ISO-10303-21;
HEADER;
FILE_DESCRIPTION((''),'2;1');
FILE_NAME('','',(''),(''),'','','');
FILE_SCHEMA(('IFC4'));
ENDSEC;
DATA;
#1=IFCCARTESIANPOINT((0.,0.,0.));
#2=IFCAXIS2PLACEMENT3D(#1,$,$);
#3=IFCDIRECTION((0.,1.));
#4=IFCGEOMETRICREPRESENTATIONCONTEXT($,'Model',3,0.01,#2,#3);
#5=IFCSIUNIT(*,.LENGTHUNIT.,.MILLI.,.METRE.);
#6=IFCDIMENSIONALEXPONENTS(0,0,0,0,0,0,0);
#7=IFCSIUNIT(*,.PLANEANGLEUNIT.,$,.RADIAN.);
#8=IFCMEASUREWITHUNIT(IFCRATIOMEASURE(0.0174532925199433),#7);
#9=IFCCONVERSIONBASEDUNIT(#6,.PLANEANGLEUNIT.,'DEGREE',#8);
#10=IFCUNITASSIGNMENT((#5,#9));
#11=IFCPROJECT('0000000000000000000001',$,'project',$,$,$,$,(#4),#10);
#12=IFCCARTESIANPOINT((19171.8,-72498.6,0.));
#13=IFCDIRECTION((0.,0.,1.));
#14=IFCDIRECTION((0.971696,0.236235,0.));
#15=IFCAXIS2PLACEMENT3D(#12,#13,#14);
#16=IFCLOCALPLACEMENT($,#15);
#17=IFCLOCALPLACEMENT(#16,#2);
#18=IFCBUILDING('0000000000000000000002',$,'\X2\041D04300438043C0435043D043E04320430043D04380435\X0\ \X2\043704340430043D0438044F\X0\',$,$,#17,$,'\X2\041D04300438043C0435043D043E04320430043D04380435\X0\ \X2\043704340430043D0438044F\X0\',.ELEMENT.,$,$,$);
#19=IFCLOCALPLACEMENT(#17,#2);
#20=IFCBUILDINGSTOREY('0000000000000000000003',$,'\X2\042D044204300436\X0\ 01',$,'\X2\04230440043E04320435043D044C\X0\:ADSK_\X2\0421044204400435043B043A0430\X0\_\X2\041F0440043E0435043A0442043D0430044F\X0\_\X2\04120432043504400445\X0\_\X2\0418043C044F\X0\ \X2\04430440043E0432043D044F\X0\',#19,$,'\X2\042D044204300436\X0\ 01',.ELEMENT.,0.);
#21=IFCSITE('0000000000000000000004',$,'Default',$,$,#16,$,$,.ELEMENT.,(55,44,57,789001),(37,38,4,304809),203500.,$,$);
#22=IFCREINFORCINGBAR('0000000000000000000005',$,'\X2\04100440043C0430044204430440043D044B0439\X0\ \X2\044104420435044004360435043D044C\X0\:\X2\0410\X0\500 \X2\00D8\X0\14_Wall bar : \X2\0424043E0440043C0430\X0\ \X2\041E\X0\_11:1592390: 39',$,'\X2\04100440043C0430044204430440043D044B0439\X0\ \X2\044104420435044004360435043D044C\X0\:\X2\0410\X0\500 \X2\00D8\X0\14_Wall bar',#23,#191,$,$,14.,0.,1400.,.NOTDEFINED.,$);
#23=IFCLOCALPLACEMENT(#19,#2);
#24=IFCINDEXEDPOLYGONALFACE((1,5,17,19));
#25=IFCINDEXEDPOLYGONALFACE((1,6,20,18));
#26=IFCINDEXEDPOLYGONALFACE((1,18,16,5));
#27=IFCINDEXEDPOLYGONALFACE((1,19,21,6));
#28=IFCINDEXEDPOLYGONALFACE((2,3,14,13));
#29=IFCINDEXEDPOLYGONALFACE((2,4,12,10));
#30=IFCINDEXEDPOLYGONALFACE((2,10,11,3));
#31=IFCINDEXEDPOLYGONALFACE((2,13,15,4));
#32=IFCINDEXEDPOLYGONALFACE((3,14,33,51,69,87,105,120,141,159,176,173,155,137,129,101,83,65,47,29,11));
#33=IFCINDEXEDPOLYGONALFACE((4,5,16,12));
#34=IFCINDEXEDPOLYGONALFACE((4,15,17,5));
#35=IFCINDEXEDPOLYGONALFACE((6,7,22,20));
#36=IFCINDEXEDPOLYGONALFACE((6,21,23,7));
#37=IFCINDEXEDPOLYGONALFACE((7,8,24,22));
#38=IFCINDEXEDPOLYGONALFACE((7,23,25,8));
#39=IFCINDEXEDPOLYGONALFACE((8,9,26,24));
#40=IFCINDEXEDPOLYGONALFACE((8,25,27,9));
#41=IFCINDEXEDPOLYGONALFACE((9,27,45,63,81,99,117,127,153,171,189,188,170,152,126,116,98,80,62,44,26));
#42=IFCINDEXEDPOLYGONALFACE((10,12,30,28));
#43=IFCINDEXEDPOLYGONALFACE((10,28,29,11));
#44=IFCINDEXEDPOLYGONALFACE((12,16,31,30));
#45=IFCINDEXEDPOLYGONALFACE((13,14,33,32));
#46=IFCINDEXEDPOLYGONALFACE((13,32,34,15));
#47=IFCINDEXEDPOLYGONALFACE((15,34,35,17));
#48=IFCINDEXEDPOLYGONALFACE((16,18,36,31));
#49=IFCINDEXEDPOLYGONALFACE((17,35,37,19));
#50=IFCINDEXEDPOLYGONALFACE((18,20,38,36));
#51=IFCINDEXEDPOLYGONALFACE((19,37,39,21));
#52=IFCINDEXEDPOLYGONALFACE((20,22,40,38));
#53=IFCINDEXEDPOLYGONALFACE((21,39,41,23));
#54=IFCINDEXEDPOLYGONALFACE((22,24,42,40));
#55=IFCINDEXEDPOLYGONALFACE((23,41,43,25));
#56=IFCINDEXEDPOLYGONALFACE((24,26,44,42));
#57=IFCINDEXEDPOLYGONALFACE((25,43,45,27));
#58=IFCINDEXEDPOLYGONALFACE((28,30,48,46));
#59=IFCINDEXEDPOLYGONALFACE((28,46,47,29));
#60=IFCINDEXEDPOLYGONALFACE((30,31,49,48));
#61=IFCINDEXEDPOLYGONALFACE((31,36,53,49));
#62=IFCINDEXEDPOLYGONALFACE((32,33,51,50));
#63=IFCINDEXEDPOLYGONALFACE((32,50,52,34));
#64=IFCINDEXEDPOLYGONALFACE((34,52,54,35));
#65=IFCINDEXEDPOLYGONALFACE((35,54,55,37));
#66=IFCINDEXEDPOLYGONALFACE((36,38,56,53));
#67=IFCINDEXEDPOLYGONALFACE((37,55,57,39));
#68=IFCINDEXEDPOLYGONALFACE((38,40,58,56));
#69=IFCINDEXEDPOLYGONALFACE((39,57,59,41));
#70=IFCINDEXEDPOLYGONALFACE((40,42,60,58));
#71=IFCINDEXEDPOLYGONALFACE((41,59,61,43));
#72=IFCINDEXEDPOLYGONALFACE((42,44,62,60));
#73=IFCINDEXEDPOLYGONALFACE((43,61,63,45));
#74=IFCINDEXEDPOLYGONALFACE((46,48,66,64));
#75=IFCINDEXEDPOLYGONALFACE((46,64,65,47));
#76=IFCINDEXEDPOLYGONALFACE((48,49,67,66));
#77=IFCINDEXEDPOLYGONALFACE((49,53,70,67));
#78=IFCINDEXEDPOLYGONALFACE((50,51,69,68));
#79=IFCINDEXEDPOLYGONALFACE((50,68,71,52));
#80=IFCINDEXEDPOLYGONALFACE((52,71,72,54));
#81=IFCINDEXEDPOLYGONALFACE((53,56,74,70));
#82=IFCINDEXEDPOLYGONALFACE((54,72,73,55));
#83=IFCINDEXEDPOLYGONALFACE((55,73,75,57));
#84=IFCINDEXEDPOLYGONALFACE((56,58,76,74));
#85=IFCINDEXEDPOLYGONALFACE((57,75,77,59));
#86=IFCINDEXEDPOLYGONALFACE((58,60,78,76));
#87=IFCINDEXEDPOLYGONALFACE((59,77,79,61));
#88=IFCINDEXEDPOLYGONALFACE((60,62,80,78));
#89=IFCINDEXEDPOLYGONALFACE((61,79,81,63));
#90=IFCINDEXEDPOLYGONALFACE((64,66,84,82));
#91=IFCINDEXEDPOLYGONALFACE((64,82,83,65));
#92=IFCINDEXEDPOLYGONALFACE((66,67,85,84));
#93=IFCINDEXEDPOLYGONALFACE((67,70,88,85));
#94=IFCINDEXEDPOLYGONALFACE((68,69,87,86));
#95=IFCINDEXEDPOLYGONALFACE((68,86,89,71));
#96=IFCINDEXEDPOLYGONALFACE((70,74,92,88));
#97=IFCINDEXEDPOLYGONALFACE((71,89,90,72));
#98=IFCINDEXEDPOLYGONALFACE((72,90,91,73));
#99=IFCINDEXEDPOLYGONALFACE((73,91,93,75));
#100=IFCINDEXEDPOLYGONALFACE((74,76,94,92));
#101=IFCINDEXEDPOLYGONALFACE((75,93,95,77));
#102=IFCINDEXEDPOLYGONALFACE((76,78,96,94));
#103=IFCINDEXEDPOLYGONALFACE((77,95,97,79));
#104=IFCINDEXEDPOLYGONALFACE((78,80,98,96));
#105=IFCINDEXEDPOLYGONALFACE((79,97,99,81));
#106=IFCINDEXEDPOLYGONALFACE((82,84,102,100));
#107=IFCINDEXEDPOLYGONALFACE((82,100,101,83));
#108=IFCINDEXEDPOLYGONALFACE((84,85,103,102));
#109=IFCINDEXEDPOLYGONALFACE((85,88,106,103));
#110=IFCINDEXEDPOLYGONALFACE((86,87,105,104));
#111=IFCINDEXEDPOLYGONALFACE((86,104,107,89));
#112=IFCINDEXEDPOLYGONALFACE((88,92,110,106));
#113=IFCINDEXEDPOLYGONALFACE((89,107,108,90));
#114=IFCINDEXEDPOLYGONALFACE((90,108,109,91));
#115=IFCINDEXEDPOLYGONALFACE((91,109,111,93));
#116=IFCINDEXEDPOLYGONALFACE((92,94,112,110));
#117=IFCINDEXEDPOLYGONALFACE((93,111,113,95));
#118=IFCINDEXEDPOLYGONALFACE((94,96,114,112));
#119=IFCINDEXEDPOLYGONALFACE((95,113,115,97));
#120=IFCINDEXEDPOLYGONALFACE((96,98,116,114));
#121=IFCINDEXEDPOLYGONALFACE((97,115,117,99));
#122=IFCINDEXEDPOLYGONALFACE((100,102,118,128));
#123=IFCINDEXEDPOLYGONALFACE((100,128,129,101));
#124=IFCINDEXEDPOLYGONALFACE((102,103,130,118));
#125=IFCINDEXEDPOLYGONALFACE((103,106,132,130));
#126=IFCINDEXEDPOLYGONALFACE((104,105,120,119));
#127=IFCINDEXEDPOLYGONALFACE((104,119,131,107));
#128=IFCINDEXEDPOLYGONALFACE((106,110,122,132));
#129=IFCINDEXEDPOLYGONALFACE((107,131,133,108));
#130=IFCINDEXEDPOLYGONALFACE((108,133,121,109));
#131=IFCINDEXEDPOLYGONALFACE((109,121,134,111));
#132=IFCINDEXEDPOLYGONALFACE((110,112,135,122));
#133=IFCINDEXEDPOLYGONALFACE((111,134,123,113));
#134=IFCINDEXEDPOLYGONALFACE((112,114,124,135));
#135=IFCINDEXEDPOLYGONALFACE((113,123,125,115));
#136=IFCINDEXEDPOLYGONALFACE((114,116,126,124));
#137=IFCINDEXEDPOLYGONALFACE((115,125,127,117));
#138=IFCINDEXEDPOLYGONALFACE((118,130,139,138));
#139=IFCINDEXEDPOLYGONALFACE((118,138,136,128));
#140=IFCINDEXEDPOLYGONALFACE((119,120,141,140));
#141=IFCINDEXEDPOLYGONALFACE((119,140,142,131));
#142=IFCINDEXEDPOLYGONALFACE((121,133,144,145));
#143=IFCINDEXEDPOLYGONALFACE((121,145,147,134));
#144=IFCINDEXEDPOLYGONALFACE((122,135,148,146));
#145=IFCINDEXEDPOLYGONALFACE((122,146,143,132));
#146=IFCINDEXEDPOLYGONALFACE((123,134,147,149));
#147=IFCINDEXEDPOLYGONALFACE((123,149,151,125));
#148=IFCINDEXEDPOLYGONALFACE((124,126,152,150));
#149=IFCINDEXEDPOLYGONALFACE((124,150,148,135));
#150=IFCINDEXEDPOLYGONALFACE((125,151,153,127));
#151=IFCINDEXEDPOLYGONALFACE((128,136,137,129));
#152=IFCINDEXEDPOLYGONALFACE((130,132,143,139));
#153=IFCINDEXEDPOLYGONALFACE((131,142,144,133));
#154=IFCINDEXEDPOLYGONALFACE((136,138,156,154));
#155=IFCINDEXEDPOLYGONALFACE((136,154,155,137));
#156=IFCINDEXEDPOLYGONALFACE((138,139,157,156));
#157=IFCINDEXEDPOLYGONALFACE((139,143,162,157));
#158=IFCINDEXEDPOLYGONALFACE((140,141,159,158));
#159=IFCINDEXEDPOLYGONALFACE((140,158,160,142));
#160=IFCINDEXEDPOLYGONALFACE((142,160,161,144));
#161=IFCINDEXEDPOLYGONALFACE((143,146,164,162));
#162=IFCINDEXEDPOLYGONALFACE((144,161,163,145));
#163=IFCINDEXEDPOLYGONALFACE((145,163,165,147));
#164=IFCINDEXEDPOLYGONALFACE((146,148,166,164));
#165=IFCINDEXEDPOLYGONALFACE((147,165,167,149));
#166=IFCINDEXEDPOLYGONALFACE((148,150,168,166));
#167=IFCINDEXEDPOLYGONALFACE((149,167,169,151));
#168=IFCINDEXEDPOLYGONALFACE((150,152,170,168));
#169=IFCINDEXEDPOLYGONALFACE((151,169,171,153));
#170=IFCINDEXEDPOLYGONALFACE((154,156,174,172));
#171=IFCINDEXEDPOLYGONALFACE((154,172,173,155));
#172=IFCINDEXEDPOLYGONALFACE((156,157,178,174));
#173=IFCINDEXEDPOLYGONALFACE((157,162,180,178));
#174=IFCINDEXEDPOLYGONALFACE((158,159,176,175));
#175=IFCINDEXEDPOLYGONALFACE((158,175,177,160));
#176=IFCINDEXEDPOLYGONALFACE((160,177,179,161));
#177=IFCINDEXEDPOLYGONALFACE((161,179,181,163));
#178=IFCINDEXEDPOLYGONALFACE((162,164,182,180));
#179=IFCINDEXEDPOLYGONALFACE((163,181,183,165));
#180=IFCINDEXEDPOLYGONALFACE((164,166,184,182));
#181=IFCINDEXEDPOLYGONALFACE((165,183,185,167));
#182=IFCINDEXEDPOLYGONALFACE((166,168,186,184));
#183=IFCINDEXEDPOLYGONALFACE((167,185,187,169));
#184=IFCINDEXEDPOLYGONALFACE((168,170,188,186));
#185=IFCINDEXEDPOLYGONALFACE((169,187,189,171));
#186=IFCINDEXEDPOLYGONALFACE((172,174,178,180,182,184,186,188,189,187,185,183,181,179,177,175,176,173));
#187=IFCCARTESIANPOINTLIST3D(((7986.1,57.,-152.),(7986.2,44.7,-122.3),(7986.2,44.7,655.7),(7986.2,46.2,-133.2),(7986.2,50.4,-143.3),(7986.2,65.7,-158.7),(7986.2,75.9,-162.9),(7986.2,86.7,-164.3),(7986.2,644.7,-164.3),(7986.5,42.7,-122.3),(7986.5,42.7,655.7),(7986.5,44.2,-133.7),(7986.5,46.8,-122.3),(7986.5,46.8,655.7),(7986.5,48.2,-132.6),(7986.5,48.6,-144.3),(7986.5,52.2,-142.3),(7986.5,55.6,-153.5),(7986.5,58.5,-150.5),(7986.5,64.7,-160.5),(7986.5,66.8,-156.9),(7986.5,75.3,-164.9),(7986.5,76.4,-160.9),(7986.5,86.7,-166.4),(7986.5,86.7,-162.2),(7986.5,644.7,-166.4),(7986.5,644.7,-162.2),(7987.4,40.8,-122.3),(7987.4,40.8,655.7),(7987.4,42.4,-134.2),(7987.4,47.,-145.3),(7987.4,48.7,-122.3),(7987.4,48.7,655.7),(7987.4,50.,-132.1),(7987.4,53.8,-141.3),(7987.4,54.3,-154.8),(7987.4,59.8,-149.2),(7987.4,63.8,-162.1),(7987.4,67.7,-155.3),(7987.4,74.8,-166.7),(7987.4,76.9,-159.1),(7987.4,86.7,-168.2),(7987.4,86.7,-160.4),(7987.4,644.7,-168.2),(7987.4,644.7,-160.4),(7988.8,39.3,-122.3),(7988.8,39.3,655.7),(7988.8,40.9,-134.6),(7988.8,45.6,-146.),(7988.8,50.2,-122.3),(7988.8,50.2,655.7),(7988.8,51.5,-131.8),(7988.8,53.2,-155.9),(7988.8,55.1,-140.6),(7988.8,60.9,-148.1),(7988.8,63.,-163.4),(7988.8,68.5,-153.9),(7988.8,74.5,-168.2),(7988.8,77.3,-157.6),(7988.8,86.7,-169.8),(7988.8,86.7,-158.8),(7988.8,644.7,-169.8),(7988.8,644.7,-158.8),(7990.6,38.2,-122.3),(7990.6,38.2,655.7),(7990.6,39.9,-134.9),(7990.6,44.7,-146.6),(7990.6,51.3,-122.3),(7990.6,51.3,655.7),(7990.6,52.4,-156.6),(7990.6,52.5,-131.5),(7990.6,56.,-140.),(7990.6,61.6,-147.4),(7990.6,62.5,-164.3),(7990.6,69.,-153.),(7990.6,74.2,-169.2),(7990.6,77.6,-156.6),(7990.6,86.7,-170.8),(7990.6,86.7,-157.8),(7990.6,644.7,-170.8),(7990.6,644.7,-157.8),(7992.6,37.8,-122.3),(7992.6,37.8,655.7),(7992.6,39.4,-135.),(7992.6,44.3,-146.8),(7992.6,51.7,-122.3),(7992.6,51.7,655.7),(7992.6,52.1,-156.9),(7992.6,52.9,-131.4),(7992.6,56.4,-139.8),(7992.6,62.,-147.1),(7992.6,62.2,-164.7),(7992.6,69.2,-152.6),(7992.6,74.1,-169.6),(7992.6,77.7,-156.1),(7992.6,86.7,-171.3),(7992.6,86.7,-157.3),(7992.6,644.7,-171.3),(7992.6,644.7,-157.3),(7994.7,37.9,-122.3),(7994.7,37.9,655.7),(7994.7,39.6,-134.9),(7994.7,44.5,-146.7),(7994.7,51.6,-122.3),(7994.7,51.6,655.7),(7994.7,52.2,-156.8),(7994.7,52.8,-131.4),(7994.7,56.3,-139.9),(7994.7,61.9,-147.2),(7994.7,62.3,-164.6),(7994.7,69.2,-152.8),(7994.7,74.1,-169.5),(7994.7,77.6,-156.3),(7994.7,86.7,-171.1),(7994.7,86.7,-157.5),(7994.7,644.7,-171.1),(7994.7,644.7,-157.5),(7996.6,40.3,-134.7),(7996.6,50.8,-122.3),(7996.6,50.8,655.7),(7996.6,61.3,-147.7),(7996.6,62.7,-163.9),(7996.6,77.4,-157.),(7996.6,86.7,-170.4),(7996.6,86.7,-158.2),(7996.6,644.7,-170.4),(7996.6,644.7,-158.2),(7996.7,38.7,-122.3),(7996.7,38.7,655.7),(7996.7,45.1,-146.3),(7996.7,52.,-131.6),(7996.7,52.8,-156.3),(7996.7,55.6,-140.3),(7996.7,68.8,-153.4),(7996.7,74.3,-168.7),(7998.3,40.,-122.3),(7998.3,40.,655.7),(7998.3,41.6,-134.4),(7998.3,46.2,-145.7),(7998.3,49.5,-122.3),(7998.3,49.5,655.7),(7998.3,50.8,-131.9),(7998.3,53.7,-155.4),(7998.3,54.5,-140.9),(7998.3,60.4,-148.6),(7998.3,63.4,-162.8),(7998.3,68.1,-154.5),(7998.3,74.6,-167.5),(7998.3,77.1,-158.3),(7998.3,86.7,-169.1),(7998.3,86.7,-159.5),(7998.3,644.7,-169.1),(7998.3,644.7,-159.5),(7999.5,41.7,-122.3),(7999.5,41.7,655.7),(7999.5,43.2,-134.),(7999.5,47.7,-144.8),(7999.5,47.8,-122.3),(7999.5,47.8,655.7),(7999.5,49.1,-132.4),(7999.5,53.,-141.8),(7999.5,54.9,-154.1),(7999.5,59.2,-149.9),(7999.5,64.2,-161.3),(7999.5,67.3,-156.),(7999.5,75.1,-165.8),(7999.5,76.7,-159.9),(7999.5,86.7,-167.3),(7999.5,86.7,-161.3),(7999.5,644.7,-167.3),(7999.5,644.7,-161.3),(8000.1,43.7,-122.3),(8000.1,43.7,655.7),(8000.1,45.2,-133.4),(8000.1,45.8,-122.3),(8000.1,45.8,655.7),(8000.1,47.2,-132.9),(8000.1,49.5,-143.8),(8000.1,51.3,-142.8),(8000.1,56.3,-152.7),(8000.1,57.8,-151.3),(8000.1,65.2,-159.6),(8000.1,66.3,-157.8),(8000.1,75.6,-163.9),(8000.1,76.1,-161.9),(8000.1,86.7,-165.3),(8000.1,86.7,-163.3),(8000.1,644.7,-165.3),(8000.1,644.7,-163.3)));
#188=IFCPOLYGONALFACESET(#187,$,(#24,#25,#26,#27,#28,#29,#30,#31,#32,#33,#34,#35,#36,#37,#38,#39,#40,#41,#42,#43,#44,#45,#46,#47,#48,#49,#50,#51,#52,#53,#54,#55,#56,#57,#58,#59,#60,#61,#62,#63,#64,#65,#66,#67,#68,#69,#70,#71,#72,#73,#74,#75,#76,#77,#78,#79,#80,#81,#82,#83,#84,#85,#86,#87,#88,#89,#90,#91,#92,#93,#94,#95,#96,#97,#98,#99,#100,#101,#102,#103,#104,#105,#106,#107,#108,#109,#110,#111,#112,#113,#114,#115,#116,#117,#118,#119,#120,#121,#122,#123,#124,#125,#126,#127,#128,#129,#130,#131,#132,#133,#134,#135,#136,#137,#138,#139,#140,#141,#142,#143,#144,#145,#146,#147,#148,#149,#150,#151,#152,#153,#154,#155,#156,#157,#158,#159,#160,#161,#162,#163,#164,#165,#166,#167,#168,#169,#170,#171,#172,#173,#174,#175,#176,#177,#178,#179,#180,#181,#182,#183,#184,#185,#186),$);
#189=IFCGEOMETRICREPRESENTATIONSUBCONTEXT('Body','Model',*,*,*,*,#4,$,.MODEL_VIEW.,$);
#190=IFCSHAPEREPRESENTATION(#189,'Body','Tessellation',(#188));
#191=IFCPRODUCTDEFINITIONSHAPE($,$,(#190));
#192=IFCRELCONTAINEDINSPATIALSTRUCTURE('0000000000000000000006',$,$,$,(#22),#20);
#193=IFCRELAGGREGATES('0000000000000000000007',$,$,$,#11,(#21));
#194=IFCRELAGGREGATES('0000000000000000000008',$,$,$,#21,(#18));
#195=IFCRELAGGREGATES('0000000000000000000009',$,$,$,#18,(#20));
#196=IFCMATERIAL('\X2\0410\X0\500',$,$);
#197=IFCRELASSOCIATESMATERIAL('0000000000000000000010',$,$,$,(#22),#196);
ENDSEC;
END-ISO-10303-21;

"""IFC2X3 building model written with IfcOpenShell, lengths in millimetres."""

from ifc_helpers import new_model, entity, si_unit, converted_unit, direction, frame, origin, place, context, subcontext, project, spatial, material, element, save


model = new_model("IFC2X3")

# Units and contexts
model_context = context("Model", 3, precision=0.01, world=origin(), true_north=direction((0.0, 1.0)))
body_context = subcontext(model_context, "Body", "Model", "MODEL_VIEW")
ifc_project = project(units=[si_unit("LENGTHUNIT", "METRE", prefix="MILLI"), converted_unit("PLANEANGLEUNIT", "DEGREE", entity("IfcRatioMeasure", 0.0174532925199433), si_unit("PLANEANGLEUNIT", "RADIAN"), dimensions=[0, 0, 0, 0, 0, 0, 0])], contexts=[model_context])

# Site, building, storey
site_placement = place(None, frame((19171.8, -72498.6, 0.0), z_axis=(0.0, 0.0, 1.0), x_axis=(0.971696, 0.236235, 0.0)))
site = spatial("IfcSite", under=ifc_project, at=site_placement, Name="Default", CompositionType="ELEMENT", RefLatitude=(55, 44, 57, 789001), RefLongitude=(37, 38, 4, 304809), RefElevation=203500.0)
building_placement = place(site_placement, origin())
building = spatial("IfcBuilding", under=site, at=building_placement, Name="Наименование здания", LongName="Наименование здания", CompositionType="ELEMENT")
storey_placement = place(building_placement, origin())
storey = spatial("IfcBuildingStorey", under=building, at=storey_placement, Name="Этаж 01", ObjectType="Уровень:ADSK_Стрелка_Проектная_Вверх_Имя уровня", LongName="Этаж 01", CompositionType="ELEMENT", Elevation=0.0)

# Reinforcing bar
ifc_material = material(Name="А500")
placement = place(storey_placement, origin())
element("IfcReinforcingBar", 1, at=placement, inside=storey, material=ifc_material, Name="Арматурный стержень:А500 Ø14_Wall bar : Форма О_11:1592390: 39", ObjectType="Арматурный стержень:А500 Ø14_Wall bar", BarLength=1400.0, BarRole="NOTDEFINED", CrossSectionArea=0.0, NominalDiameter=14.0, context=body_context, shape_type="AdvancedSweptSolid", body=[
    entity("IfcSweptDiskSolid", entity("IfcCompositeCurve", [entity("IfcCompositeCurveSegment", "CONTINUOUS", True, entity("IfcPolyline", [entity("IfcCartesianPoint", [7993.1, 44.7, 655.7]), entity("IfcCartesianPoint", [7993.1, 44.7, -122.3])])), entity("IfcCompositeCurveSegment", "CONTINUOUS", True, entity("IfcTrimmedCurve", entity("IfcCircle", entity("IfcAxis2Placement3D", entity("IfcCartesianPoint", [7993.1, 86.7, -122.3]), entity("IfcDirection", [1.0, 0.0, 0.0]), entity("IfcDirection", [0.0, 0.0, -1.0])), 42.0), [entity("IfcParameterValue", 270.0)], [entity("IfcParameterValue", 360.0)], True, "PARAMETER")), entity("IfcCompositeCurveSegment", "CONTINUOUS", True, entity("IfcPolyline", [entity("IfcCartesianPoint", [7993.1, 86.7, -164.3]), entity("IfcCartesianPoint", [7993.1, 644.7, -164.3])]))], False), 7.0, None, 0.0, 92.0),
])

save(model, "model.ifc")
